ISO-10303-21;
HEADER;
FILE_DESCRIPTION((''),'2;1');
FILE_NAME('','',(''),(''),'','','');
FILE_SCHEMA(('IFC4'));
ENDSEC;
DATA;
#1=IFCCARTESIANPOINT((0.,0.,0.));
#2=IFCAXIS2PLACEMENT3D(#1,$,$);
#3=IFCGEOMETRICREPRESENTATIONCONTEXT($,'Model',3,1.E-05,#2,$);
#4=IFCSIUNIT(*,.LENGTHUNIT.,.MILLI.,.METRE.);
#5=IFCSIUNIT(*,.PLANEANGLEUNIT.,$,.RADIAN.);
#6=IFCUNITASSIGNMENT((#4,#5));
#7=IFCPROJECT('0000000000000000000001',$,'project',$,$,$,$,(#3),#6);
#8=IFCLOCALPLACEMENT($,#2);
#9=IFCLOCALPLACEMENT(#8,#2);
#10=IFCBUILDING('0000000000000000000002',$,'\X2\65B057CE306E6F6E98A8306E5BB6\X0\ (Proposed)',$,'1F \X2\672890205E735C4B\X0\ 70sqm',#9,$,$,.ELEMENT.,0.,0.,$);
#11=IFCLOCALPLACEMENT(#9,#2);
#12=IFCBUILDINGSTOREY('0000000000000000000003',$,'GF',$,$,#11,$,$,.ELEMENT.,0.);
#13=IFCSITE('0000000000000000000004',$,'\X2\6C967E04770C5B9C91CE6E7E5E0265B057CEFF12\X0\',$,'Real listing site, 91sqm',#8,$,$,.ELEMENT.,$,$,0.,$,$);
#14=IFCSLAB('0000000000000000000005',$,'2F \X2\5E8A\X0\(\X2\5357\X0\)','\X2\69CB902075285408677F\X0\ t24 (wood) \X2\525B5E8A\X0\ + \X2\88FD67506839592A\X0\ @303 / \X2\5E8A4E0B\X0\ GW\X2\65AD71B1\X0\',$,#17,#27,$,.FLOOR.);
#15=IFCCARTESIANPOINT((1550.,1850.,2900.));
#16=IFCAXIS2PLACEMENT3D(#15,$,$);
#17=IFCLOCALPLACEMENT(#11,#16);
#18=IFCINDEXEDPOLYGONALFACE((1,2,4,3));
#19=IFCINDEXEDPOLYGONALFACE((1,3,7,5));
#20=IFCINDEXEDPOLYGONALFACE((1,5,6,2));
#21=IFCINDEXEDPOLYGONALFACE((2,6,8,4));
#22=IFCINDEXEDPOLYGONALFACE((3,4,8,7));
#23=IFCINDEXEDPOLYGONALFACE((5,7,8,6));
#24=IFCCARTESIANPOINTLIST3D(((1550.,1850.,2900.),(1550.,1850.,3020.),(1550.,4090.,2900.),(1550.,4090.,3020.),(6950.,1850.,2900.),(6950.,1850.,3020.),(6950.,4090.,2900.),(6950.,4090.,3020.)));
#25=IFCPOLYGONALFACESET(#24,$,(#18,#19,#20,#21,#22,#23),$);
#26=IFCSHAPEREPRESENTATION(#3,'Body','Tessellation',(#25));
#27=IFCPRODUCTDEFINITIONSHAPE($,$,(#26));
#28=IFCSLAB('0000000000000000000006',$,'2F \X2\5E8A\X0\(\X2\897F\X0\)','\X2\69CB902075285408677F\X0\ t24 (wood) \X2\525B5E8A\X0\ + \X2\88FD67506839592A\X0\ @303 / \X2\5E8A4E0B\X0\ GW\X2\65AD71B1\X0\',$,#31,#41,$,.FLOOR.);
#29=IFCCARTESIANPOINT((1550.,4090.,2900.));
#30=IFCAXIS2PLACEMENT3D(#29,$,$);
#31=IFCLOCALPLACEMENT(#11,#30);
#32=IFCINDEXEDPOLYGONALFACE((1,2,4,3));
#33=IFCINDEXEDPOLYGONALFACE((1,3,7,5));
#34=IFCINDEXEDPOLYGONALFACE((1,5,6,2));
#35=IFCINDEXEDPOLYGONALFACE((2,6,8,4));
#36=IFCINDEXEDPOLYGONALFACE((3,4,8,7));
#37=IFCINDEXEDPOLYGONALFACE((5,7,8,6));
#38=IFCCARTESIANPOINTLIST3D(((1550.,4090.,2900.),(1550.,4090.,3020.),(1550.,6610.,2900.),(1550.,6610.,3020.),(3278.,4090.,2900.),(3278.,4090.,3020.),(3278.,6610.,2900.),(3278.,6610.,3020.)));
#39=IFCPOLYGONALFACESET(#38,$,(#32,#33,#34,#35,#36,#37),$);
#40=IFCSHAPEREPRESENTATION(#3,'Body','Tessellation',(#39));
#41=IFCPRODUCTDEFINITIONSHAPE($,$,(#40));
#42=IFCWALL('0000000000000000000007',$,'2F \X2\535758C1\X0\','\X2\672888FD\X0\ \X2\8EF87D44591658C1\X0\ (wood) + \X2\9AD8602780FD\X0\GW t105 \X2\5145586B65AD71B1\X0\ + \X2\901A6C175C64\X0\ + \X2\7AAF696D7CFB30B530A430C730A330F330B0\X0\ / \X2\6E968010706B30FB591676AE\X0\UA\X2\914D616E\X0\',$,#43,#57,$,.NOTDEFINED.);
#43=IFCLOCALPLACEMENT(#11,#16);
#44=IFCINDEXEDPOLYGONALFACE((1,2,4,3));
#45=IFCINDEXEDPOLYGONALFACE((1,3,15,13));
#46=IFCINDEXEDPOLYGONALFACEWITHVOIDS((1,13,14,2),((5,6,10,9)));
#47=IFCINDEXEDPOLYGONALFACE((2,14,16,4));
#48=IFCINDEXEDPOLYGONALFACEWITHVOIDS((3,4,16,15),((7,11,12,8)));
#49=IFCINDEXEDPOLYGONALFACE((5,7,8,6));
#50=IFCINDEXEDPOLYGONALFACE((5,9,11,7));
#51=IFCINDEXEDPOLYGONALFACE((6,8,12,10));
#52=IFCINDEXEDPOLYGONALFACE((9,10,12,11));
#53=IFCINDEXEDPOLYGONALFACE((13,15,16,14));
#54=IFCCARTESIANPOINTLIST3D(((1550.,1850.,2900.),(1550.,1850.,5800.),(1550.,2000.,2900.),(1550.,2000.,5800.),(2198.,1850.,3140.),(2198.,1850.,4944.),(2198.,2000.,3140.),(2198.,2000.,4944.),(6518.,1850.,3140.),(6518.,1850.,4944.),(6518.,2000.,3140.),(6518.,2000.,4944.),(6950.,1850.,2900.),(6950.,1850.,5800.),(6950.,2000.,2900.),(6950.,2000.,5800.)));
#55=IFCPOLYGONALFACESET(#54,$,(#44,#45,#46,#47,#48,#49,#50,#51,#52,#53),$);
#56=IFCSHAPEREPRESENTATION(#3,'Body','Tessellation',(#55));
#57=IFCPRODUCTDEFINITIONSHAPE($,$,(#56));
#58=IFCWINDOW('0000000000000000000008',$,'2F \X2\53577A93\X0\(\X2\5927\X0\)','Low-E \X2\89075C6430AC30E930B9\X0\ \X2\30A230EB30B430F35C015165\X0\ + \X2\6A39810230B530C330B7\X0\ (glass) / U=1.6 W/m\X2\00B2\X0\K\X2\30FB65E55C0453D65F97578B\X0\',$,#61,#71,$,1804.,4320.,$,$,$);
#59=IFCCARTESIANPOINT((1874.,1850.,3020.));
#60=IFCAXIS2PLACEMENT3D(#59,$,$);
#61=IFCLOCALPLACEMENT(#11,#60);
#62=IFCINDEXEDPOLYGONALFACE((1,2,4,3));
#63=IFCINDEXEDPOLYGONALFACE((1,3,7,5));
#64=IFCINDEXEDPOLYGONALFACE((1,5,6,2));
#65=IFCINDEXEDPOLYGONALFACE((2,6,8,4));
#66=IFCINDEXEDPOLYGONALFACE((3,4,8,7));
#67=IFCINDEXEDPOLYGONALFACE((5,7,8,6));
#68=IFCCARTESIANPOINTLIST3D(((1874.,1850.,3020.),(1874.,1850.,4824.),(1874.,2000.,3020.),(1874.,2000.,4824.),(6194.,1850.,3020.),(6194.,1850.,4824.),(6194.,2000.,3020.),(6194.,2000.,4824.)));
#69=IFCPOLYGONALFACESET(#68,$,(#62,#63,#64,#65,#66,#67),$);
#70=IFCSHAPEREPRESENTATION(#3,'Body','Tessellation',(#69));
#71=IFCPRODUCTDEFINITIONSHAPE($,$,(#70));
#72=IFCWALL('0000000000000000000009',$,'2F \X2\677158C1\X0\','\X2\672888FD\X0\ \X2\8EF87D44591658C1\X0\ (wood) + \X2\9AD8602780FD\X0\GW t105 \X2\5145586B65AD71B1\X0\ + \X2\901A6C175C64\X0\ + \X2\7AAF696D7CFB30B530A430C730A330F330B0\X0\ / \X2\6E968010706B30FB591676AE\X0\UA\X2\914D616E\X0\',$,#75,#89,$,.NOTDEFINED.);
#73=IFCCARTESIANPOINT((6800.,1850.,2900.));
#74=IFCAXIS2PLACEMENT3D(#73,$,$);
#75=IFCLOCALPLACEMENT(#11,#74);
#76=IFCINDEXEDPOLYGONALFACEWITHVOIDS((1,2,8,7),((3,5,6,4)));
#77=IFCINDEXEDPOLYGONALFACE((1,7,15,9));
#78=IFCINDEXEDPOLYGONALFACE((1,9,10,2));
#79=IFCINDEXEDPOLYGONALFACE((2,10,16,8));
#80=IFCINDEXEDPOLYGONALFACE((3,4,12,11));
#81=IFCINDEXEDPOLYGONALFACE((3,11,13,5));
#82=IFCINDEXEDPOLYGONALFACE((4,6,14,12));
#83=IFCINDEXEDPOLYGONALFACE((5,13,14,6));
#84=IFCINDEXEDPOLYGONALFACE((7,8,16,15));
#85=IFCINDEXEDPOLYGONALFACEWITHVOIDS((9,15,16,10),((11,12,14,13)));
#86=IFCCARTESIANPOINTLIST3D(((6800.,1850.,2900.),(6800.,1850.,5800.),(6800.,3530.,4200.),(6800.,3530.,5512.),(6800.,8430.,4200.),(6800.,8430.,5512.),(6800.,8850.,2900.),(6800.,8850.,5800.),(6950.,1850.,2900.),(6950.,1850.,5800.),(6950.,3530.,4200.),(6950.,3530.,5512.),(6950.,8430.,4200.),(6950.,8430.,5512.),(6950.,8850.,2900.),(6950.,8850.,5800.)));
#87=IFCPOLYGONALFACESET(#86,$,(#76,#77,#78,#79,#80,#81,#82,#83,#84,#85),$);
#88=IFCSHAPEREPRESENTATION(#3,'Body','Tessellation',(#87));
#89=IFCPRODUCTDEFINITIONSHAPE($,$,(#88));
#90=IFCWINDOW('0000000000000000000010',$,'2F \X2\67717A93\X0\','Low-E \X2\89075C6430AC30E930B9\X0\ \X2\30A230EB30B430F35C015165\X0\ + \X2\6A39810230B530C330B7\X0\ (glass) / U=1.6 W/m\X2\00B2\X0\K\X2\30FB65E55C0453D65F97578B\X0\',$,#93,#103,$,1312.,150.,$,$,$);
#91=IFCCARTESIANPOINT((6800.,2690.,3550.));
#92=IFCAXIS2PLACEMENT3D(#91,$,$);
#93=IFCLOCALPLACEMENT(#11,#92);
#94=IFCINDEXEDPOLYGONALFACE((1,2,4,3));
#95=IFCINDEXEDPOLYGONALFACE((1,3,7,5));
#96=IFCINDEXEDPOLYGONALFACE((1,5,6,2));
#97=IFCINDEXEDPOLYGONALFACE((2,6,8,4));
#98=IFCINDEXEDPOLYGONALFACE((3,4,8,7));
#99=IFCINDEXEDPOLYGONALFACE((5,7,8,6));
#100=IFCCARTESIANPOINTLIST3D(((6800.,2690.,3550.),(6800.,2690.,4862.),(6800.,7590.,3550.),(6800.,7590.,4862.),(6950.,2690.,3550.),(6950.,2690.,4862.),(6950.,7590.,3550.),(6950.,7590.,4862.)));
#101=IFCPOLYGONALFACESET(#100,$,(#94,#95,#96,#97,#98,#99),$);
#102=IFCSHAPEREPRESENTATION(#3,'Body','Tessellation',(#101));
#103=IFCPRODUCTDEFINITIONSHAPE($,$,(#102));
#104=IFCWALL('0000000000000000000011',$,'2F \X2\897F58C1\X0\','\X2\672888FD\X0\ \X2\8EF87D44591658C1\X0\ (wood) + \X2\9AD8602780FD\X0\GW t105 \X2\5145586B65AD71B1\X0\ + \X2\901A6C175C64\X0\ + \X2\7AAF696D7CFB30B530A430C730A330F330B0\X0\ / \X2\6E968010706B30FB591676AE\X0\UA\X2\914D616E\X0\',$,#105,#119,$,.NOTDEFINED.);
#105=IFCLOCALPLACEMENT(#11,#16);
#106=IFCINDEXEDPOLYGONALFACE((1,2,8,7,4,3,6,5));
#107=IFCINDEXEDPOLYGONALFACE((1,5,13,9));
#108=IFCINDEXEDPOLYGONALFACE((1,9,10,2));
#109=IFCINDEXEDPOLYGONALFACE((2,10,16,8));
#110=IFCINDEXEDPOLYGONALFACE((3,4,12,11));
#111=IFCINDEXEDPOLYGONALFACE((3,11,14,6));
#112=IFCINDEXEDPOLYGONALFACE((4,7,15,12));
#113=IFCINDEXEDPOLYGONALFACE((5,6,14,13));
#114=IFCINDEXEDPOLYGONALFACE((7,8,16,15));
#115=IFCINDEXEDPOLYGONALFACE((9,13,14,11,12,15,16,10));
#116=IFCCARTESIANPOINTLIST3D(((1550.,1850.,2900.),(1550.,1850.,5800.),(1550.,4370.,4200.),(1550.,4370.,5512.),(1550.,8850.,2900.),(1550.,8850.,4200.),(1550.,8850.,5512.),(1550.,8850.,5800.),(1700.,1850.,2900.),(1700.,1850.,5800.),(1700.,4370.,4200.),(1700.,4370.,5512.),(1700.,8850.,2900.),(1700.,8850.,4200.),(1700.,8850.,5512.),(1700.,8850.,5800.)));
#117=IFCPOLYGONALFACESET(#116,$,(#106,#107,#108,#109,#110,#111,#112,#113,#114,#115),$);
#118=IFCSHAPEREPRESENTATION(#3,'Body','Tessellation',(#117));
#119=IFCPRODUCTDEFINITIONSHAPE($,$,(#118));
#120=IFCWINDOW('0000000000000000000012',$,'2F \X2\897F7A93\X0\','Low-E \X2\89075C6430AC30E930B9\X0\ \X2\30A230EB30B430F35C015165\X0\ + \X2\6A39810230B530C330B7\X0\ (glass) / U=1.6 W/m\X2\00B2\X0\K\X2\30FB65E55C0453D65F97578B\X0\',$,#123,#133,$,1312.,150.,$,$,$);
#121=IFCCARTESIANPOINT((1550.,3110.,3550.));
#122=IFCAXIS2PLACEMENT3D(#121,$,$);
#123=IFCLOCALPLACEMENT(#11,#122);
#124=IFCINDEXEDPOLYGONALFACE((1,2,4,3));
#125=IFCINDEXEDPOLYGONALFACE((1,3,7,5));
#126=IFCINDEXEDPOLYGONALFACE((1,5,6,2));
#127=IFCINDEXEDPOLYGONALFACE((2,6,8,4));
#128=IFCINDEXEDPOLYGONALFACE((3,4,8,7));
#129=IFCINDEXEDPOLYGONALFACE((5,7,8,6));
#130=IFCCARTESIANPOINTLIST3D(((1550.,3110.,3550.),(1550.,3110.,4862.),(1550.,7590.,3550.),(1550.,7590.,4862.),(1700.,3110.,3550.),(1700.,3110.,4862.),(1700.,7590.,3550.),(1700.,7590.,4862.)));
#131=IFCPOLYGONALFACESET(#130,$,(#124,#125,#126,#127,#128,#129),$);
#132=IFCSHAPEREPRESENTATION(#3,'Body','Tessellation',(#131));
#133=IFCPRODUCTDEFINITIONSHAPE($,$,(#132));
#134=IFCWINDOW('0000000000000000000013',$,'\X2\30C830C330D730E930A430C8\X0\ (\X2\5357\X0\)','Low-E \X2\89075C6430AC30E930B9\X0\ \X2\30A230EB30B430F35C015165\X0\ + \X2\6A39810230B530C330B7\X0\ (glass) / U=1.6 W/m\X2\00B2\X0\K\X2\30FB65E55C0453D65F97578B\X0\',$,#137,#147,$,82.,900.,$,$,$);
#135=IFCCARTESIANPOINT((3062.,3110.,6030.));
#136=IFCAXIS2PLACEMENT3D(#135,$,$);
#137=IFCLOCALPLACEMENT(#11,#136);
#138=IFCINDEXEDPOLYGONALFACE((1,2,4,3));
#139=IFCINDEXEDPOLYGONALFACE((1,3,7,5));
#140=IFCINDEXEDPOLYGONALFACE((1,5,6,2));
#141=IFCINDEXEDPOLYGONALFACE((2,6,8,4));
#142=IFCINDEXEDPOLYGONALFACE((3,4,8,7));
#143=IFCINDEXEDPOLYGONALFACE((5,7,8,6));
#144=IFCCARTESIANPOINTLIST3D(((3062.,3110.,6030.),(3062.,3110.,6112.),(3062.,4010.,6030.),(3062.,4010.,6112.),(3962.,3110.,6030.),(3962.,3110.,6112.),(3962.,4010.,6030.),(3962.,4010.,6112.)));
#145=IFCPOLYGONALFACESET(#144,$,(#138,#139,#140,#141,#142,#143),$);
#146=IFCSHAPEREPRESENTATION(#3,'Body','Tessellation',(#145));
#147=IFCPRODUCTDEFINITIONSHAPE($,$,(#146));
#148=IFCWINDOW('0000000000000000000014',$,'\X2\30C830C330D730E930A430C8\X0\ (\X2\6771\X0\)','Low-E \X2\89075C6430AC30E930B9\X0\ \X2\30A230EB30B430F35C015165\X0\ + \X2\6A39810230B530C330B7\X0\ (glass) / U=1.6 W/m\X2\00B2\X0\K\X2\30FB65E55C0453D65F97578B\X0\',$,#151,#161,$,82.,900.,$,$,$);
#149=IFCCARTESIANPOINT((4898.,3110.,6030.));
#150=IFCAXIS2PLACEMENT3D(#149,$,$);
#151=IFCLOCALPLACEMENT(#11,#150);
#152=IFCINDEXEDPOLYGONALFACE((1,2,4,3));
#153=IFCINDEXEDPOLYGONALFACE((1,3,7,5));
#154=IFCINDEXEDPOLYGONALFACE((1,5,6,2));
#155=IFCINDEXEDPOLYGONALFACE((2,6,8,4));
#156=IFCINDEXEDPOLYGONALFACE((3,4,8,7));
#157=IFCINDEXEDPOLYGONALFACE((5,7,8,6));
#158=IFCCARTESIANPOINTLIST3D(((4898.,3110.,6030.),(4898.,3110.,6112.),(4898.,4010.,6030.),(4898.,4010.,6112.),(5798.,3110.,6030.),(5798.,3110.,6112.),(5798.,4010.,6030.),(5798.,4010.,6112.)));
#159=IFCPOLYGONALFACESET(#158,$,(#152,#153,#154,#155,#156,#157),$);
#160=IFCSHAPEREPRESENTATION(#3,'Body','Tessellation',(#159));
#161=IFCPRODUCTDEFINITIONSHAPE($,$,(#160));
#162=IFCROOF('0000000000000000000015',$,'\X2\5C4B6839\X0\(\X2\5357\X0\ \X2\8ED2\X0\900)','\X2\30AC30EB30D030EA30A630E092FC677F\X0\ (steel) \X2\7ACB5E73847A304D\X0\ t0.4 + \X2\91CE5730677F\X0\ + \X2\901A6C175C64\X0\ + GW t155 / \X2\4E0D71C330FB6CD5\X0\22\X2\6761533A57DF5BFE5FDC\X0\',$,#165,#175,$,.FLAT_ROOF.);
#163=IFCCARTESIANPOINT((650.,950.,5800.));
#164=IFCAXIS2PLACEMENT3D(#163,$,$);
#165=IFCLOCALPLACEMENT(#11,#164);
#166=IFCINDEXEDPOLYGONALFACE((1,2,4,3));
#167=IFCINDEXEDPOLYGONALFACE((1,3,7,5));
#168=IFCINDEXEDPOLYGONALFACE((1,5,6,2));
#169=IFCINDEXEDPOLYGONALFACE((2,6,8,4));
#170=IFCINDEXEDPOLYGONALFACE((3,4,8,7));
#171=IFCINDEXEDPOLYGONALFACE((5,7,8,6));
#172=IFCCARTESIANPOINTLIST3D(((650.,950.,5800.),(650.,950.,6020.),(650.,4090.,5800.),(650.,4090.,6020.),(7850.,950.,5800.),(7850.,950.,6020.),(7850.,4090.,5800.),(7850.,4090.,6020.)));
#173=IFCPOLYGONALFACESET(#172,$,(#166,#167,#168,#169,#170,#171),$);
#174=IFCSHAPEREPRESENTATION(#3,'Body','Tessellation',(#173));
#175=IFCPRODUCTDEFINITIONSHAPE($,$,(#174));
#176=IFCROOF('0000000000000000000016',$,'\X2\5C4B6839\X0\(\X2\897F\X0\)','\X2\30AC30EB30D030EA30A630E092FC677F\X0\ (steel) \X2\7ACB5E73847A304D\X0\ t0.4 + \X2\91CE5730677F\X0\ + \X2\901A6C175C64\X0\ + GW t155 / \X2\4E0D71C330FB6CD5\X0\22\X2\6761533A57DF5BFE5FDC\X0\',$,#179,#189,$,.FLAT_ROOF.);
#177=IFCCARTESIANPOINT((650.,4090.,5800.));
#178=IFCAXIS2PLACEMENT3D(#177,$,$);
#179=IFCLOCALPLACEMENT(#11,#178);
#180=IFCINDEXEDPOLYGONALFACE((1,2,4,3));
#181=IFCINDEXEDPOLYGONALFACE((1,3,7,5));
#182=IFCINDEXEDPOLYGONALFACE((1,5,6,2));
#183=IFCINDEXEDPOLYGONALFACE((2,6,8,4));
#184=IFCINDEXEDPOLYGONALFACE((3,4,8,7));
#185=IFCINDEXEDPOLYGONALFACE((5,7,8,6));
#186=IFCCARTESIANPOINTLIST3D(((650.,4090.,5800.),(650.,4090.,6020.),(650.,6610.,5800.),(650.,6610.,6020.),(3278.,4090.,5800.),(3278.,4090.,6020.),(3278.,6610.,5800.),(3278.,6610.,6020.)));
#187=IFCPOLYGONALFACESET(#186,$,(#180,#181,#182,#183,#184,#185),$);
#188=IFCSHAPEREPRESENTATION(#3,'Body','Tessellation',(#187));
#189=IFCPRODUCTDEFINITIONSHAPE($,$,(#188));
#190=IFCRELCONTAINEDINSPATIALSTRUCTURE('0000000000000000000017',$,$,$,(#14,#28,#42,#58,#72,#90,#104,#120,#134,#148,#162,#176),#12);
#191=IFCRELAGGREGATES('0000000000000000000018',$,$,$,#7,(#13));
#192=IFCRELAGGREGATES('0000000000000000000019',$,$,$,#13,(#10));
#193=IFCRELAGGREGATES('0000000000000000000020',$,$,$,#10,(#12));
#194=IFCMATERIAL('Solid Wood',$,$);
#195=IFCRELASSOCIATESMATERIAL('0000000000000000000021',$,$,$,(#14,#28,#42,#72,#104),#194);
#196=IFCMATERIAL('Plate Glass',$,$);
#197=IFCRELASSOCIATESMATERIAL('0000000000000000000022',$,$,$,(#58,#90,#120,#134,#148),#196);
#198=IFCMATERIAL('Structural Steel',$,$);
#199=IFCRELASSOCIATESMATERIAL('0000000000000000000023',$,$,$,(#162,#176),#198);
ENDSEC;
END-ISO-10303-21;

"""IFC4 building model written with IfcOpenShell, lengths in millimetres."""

from ifc_helpers import new_model, si_unit, frame, frame_2d, origin, place, context, project, spatial, rectangle, extrude, material, element, fill, save


model = new_model("IFC4")

# Units and contexts
model_context = context("Model", 3, precision=1e-05, world=origin())
ifc_project = project(units=[si_unit("LENGTHUNIT", "METRE", prefix="MILLI"), si_unit("PLANEANGLEUNIT", "RADIAN")], contexts=[model_context])

# Site, building, storey
site_placement = place(None, origin())
site = spatial("IfcSite", under=ifc_project, at=site_placement, Name="沖縄県宜野湾市新城２", ObjectType="Real listing site, 91sqm", CompositionType="ELEMENT", RefElevation=0.0)
building_placement = place(site_placement, origin())
building = spatial("IfcBuilding", under=site, at=building_placement, Name="新城の潮風の家 (Proposed)", ObjectType="1F 木造平屋 70sqm", CompositionType="ELEMENT", ElevationOfRefHeight=0.0, ElevationOfTerrain=0.0)
storey_placement = place(building_placement, origin())
storey = spatial("IfcBuildingStorey", under=building, at=storey_placement, Name="GF", CompositionType="ELEMENT", Elevation=0.0)

# Slabs
ifc_material_1 = material(Name="Solid Wood")
slab_1_placement = place(storey_placement, frame((1550.0, 1850.0, 2900.0)))
element("IfcSlab", 1, at=slab_1_placement, inside=storey, material=ifc_material_1, Name="2F 床(南)", Description="構造用合板 t24 (wood) 剛床 + 製材根太 @303 / 床下 GW断熱", PredefinedType="FLOOR", context=model_context, shape_type="SweptSolid", body=[
    extrude(rectangle(XDim=5400.0, YDim=2240.0, at=frame_2d((2700.0, 1120.0))), frame((1550.0, 1850.0, 2900.0)), (0.0, 0.0, 1.0), 120.0),
])
slab_2_placement = place(storey_placement, frame((1550.0, 4090.0, 2900.0)))
element("IfcSlab", 2, at=slab_2_placement, inside=storey, material=ifc_material_1, Name="2F 床(西)", Description="構造用合板 t24 (wood) 剛床 + 製材根太 @303 / 床下 GW断熱", PredefinedType="FLOOR", context=model_context, shape_type="SweptSolid", body=[
    extrude(rectangle(XDim=1728.0, YDim=2520.0, at=frame_2d((864.0, 1260.0))), frame((1550.0, 4090.0, 2900.0)), (0.0, 0.0, 1.0), 120.0),
])

# Walls, openings, windows
wall_1_placement = place(storey_placement, frame((1550.0, 1850.0, 2900.0)))
wall_1 = element("IfcWall", 3, at=wall_1_placement, inside=storey, material=ifc_material_1, Name="2F 南壁", Description="木製 軸組外壁 (wood) + 高性能GW t105 充填断熱 + 通気層 + 窯業系サイディング / 準耐火・外皮UA配慮", PredefinedType="NOTDEFINED", context=model_context, shape_type="SweptSolid", body=[
    extrude(rectangle(XDim=5400.0, YDim=150.0, at=frame_2d((2700.0, 75.0))), frame((1550.0, 1850.0, 2900.0)), (0.0, 0.0, 1.0), 2900.0),
])
opening_1_placement = place(storey_placement, frame((1874.0, 1850.0, 3020.0)))
opening_1 = element("IfcOpeningElement", 4, at=opening_1_placement, cuts=wall_1, PredefinedType="NOTDEFINED", context=model_context, shape_type="SweptSolid", body=[
    extrude(rectangle(XDim=4320.0, YDim=150.0, at=frame_2d((2160.0, 75.0))), frame((1874.0, 1850.0, 3020.0)), (0.0, 0.0, 1.0), 1804.0),
])
ifc_material_2 = material(Name="Plate Glass")
window_1_placement = place(storey_placement, frame((1874.0, 1850.0, 3020.0)))
window_1 = element("IfcWindow", 5, at=window_1_placement, inside=storey, material=ifc_material_2, Name="2F 南窓(大)", Description="Low-E 複層ガラス アルゴン封入 + 樹脂サッシ (glass) / U=1.6 W/m²K・日射取得型", OverallHeight=1804.0, OverallWidth=4320.0, context=model_context, shape_type="SweptSolid", body=[
    extrude(rectangle(XDim=4320.0, YDim=150.0, at=frame_2d((2160.0, 75.0))), frame((1874.0, 1850.0, 3020.0)), (0.0, 0.0, 1.0), 1804.0),
])
fill(opening_1, window_1)
wall_2_placement = place(storey_placement, frame((6800.0, 1850.0, 2900.0)))
wall_2 = element("IfcWall", 6, at=wall_2_placement, inside=storey, material=ifc_material_1, Name="2F 東壁", Description="木製 軸組外壁 (wood) + 高性能GW t105 充填断熱 + 通気層 + 窯業系サイディング / 準耐火・外皮UA配慮", PredefinedType="NOTDEFINED", context=model_context, shape_type="SweptSolid", body=[
    extrude(rectangle(XDim=150.0, YDim=7000.0, at=frame_2d((75.0, 3500.0))), frame((6800.0, 1850.0, 2900.0)), (0.0, 0.0, 1.0), 2900.0),
])
opening_2_placement = place(storey_placement, frame((6800.0, 2690.0, 3550.0)))
opening_2 = element("IfcOpeningElement", 7, at=opening_2_placement, cuts=wall_2, PredefinedType="NOTDEFINED", context=model_context, shape_type="SweptSolid", body=[
    extrude(rectangle(XDim=150.0, YDim=4900.0, at=frame_2d((75.0, 2450.0))), frame((6800.0, 2690.0, 3550.0)), (0.0, 0.0, 1.0), 1312.0),
])
window_2_placement = place(storey_placement, frame((6800.0, 2690.0, 3550.0)))
window_2 = element("IfcWindow", 8, at=window_2_placement, inside=storey, material=ifc_material_2, Name="2F 東窓", Description="Low-E 複層ガラス アルゴン封入 + 樹脂サッシ (glass) / U=1.6 W/m²K・日射取得型", OverallHeight=1312.0, OverallWidth=150.0, context=model_context, shape_type="SweptSolid", body=[
    extrude(rectangle(XDim=150.0, YDim=4900.0, at=frame_2d((75.0, 2450.0))), frame((6800.0, 2690.0, 3550.0)), (0.0, 0.0, 1.0), 1312.0),
])
fill(opening_2, window_2)
wall_3_placement = place(storey_placement, frame((1550.0, 1850.0, 2900.0)))
wall_3 = element("IfcWall", 9, at=wall_3_placement, inside=storey, material=ifc_material_1, Name="2F 西壁", Description="木製 軸組外壁 (wood) + 高性能GW t105 充填断熱 + 通気層 + 窯業系サイディング / 準耐火・外皮UA配慮", PredefinedType="NOTDEFINED", context=model_context, shape_type="SweptSolid", body=[
    extrude(rectangle(XDim=150.0, YDim=7000.0, at=frame_2d((75.0, 3500.0))), frame((1550.0, 1850.0, 2900.0)), (0.0, 0.0, 1.0), 2900.0),
])
opening_3_placement = place(storey_placement, frame((1550.0, 3110.0, 3550.0)))
opening_3 = element("IfcOpeningElement", 10, at=opening_3_placement, cuts=wall_3, PredefinedType="NOTDEFINED", context=model_context, shape_type="SweptSolid", body=[
    extrude(rectangle(XDim=150.0, YDim=4480.0, at=frame_2d((75.0, 2240.0))), frame((1550.0, 3110.0, 3550.0)), (0.0, 0.0, 1.0), 1312.0),
])
window_3_placement = place(storey_placement, frame((1550.0, 3110.0, 3550.0)))
window_3 = element("IfcWindow", 11, at=window_3_placement, inside=storey, material=ifc_material_2, Name="2F 西窓", Description="Low-E 複層ガラス アルゴン封入 + 樹脂サッシ (glass) / U=1.6 W/m²K・日射取得型", OverallHeight=1312.0, OverallWidth=150.0, context=model_context, shape_type="SweptSolid", body=[
    extrude(rectangle(XDim=150.0, YDim=4480.0, at=frame_2d((75.0, 2240.0))), frame((1550.0, 3110.0, 3550.0)), (0.0, 0.0, 1.0), 1312.0),
])
fill(opening_3, window_3)

# Windows
window_4_placement = place(storey_placement, frame((3062.0, 3110.0, 6030.0)))
element("IfcWindow", 12, at=window_4_placement, inside=storey, material=ifc_material_2, Name="トップライト (南)", Description="Low-E 複層ガラス アルゴン封入 + 樹脂サッシ (glass) / U=1.6 W/m²K・日射取得型", OverallHeight=82.0, OverallWidth=900.0, context=model_context, shape_type="SweptSolid", body=[
    extrude(rectangle(XDim=900.0, YDim=900.0, at=frame_2d((450.0, 450.0))), frame((3062.0, 3110.0, 6030.0)), (0.0, 0.0, 1.0), 82.0),
])
window_5_placement = place(storey_placement, frame((4898.0, 3110.0, 6030.0)))
element("IfcWindow", 13, at=window_5_placement, inside=storey, material=ifc_material_2, Name="トップライト (東)", Description="Low-E 複層ガラス アルゴン封入 + 樹脂サッシ (glass) / U=1.6 W/m²K・日射取得型", OverallHeight=82.0, OverallWidth=900.0, context=model_context, shape_type="SweptSolid", body=[
    extrude(rectangle(XDim=900.0, YDim=900.0, at=frame_2d((450.0, 450.0))), frame((4898.0, 3110.0, 6030.0)), (0.0, 0.0, 1.0), 82.0),
])

# Roofs
ifc_material_3 = material(Name="Structural Steel")
roof_1_placement = place(storey_placement, frame((650.0, 950.0, 5800.0)))
element("IfcRoof", 14, at=roof_1_placement, inside=storey, material=ifc_material_3, Name="屋根(南 軒900)", Description="ガルバリウム鋼板 (steel) 立平葺き t0.4 + 野地板 + 通気層 + GW t155 / 不燃・法22条区域対応", PredefinedType="FLAT_ROOF", context=model_context, shape_type="SweptSolid", body=[
    extrude(rectangle(XDim=7200.0, YDim=3140.0, at=frame_2d((3600.0, 1570.0))), frame((650.0, 950.0, 5800.0)), (0.0, 0.0, 1.0), 220.0),
])
roof_2_placement = place(storey_placement, frame((650.0, 4090.0, 5800.0)))
element("IfcRoof", 15, at=roof_2_placement, inside=storey, material=ifc_material_3, Name="屋根(西)", Description="ガルバリウム鋼板 (steel) 立平葺き t0.4 + 野地板 + 通気層 + GW t155 / 不燃・法22条区域対応", PredefinedType="FLAT_ROOF", context=model_context, shape_type="SweptSolid", body=[
    extrude(rectangle(XDim=2628.0, YDim=2520.0, at=frame_2d((1314.0, 1260.0))), frame((650.0, 4090.0, 5800.0)), (0.0, 0.0, 1.0), 220.0),
])

save(model, "model.ifc")
